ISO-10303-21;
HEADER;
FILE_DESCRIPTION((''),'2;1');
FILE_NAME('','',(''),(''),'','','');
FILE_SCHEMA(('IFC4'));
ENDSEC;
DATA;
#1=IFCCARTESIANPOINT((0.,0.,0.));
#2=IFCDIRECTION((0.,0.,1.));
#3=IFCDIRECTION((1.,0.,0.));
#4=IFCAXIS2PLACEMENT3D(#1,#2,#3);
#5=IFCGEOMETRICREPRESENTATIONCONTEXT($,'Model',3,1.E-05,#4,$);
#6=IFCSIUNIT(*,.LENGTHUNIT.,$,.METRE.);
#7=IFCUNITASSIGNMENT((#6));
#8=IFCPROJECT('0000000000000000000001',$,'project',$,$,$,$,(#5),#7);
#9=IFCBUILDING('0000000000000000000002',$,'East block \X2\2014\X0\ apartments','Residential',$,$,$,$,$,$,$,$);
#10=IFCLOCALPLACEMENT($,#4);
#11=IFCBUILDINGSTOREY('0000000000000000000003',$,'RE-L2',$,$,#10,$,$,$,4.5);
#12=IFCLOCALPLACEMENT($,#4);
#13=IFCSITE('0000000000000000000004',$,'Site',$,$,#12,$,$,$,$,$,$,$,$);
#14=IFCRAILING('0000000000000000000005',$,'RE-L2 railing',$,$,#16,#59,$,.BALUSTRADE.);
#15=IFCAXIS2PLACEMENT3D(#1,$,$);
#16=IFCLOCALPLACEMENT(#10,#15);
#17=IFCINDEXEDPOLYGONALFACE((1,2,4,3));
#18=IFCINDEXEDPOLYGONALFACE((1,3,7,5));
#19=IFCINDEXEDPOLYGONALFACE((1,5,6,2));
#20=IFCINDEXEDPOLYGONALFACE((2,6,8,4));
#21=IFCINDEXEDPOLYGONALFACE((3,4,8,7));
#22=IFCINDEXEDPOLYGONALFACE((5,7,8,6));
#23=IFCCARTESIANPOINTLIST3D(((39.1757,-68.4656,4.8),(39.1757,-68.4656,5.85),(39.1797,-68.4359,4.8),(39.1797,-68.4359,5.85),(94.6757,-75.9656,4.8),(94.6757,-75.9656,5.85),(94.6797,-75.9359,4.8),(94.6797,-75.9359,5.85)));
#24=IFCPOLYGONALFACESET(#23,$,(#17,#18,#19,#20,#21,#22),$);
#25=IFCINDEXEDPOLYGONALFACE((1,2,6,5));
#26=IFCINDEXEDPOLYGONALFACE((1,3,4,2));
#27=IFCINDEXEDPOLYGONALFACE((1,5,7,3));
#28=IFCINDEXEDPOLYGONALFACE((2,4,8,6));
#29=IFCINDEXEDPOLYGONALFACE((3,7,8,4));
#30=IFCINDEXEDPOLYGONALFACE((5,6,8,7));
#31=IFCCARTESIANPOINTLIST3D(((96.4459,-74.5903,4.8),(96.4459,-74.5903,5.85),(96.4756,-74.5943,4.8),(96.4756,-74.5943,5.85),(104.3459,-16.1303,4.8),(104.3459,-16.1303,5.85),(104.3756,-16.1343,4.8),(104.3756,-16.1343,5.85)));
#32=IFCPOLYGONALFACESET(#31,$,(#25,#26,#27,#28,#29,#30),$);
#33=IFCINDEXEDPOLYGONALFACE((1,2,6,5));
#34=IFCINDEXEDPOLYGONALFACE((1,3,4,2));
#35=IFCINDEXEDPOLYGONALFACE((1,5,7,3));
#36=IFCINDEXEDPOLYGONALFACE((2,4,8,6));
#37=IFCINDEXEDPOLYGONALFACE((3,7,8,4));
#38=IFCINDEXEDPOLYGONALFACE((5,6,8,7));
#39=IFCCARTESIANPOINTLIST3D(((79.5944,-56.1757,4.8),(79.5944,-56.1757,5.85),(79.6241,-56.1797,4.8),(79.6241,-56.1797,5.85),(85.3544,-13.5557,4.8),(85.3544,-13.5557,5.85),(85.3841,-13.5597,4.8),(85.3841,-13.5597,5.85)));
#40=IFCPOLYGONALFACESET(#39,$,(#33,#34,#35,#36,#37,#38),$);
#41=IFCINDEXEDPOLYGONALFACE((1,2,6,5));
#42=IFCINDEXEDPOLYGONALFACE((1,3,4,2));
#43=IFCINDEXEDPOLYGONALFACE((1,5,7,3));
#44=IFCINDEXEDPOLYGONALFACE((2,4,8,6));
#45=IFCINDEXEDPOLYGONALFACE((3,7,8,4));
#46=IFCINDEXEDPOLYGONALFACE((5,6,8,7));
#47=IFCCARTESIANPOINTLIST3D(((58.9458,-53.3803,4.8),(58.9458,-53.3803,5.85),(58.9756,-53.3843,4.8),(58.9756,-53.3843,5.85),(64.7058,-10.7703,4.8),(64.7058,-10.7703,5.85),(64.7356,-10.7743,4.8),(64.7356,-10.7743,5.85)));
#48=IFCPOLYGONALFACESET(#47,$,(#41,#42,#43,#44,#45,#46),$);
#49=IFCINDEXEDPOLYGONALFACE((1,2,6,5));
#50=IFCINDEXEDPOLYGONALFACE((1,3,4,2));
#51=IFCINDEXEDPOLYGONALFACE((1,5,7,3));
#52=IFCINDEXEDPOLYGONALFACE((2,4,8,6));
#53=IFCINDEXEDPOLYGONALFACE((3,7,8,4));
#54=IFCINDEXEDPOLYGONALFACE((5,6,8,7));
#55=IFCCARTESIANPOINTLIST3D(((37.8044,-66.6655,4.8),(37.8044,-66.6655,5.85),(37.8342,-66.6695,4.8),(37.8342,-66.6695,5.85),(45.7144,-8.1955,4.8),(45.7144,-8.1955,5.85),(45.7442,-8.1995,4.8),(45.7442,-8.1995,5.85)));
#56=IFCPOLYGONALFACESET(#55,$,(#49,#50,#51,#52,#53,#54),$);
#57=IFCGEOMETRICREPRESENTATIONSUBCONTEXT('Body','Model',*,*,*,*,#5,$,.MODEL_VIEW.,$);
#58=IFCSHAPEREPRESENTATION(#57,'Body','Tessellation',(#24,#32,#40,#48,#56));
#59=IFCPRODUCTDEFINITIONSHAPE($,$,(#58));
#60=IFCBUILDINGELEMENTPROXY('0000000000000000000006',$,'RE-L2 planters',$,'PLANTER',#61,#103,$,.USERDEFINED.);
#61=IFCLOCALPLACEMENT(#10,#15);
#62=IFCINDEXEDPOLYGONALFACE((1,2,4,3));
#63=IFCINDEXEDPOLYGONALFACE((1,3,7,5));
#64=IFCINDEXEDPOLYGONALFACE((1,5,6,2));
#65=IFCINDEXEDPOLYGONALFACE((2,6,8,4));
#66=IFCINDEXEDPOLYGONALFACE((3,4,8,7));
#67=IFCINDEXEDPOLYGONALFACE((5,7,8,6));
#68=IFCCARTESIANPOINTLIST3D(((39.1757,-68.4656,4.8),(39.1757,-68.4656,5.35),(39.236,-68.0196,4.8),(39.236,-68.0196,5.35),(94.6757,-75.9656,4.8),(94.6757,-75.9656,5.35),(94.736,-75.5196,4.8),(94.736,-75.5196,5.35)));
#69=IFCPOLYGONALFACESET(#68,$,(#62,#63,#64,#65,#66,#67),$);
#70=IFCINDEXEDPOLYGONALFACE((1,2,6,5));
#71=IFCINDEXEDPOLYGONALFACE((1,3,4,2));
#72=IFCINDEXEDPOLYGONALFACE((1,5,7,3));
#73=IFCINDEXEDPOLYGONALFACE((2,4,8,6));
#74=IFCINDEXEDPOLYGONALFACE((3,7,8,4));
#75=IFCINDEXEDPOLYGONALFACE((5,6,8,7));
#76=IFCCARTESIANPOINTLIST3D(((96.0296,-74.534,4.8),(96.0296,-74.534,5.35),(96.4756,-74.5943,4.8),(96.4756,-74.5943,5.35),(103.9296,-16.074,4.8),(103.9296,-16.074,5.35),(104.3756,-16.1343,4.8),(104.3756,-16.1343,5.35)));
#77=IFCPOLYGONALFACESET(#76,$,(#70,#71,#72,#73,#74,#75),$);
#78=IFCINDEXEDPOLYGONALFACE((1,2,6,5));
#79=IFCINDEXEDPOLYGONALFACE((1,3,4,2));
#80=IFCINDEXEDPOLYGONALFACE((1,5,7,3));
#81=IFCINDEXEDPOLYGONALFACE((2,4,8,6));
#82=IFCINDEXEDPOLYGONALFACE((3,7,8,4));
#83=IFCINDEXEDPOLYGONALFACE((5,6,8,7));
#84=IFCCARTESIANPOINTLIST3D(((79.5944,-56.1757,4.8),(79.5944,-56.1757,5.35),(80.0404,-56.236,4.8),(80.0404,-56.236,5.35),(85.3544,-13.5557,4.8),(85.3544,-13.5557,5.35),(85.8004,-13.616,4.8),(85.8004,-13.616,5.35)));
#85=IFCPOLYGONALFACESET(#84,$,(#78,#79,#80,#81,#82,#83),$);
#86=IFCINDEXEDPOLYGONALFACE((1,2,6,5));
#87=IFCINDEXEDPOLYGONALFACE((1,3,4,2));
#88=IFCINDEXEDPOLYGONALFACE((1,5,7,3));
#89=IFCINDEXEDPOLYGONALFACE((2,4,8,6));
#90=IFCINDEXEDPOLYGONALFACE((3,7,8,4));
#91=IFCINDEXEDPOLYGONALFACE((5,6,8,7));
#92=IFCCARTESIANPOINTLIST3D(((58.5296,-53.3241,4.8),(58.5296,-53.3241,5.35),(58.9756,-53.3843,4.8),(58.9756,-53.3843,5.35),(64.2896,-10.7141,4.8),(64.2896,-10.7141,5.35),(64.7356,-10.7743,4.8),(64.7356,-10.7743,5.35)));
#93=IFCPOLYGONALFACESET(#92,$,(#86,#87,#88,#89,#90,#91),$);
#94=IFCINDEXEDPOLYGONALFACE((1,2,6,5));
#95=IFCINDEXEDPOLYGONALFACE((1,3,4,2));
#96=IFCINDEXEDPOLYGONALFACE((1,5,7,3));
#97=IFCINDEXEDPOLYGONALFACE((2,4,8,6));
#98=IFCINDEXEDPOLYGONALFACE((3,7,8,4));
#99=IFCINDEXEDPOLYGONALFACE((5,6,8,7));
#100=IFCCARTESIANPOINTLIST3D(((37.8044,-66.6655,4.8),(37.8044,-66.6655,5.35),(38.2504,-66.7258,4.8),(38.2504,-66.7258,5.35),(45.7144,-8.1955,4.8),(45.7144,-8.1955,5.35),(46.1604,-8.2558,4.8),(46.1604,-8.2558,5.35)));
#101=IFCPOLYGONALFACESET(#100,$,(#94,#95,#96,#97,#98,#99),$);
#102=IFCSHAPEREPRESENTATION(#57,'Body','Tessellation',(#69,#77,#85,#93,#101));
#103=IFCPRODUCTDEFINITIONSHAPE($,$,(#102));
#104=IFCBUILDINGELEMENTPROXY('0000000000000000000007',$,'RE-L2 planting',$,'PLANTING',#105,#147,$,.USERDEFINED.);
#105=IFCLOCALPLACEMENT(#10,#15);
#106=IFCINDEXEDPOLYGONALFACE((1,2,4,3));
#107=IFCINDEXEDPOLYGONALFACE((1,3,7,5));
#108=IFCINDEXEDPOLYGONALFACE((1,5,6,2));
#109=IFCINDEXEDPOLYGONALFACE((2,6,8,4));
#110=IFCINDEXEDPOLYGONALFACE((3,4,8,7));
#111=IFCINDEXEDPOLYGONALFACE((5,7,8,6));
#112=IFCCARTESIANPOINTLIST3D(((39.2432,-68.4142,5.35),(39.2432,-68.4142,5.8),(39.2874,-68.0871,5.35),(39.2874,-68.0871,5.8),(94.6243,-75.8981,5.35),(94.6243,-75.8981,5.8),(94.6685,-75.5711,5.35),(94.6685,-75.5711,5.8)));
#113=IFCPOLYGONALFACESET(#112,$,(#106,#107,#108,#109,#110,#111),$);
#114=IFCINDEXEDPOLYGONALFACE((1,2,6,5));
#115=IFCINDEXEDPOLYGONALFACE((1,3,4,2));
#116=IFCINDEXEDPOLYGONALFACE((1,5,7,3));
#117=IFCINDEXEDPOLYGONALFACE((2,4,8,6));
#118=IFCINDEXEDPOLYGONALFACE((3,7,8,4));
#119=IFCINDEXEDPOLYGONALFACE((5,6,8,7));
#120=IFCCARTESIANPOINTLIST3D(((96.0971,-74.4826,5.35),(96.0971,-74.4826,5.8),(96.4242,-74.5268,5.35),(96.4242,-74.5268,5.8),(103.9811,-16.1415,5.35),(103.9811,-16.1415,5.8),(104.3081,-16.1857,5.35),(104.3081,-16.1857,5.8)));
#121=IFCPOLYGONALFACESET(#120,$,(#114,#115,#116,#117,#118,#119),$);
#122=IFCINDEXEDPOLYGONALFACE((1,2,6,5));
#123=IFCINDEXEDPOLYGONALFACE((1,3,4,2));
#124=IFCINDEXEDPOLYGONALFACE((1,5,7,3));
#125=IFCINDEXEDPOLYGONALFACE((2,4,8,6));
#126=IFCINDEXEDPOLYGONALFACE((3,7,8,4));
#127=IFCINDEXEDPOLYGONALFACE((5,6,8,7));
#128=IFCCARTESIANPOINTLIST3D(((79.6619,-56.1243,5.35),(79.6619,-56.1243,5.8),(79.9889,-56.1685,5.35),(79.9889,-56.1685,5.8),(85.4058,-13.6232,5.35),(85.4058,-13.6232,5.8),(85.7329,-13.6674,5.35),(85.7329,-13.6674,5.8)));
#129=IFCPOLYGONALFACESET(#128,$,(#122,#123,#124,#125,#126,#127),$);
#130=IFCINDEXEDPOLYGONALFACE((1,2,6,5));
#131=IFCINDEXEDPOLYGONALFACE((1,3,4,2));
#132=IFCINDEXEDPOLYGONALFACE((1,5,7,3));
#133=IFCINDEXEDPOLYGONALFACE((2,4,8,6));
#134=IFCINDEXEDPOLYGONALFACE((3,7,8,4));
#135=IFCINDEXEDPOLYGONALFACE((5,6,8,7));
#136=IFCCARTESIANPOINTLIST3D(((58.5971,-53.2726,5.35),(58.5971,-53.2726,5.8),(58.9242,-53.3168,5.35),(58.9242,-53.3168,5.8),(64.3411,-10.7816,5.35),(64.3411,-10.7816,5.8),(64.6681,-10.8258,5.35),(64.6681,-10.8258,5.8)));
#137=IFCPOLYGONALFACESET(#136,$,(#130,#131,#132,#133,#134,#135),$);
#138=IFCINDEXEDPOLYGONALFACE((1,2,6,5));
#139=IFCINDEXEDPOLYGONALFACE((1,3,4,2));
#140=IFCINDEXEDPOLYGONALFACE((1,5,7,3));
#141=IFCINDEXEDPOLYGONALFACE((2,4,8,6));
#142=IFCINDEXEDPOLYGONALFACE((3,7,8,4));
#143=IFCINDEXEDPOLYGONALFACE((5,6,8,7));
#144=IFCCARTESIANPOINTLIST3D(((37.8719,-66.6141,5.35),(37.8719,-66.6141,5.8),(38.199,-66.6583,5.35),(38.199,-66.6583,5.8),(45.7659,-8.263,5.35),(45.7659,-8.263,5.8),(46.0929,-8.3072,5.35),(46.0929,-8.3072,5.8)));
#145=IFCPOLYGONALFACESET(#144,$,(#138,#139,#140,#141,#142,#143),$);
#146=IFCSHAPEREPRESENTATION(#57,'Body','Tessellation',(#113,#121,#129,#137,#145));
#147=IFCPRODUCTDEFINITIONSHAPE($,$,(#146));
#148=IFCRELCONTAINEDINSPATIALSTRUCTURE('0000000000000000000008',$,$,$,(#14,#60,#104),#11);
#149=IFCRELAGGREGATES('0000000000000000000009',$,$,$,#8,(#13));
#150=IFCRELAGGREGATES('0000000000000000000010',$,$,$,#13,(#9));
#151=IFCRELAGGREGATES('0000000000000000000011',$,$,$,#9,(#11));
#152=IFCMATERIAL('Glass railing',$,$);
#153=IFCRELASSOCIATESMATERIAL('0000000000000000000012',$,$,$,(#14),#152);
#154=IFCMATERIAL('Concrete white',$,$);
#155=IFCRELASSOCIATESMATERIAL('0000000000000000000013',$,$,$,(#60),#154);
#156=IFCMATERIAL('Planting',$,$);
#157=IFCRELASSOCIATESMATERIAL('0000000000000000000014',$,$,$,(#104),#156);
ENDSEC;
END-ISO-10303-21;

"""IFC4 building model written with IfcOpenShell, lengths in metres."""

from ifc_helpers import new_model, si_unit, frame, origin_with_axes, place, context, subcontext, project, spatial, polyline, outline, extrude, material, element, save


model = new_model("IFC4")

# Units and contexts
model_context = context("Model", 3, precision=1e-05, world=origin_with_axes())
body_context = subcontext(model_context, "Body", "Model", "MODEL_VIEW")
ifc_project = project(units=[si_unit("LENGTHUNIT", "METRE")], contexts=[model_context])

# Site, building, storey
site_placement = place(None, origin_with_axes())
site = spatial("IfcSite", under=ifc_project, at=site_placement, Name="Site")
building = spatial("IfcBuilding", under=site, Name="East block — apartments", Description="Residential")
storey_placement = place(None, origin_with_axes())
storey = spatial("IfcBuildingStorey", under=building, at=storey_placement, Name="RE-L2", Elevation=4.5)

# Railing
ifc_material_1 = material(Name="Glass railing")
railing_placement = place(storey_placement, origin_with_axes())
element("IfcRailing", 1, at=railing_placement, inside=storey, material=ifc_material_1, Name="RE-L2 railing", PredefinedType="BALUSTRADE", context=body_context, shape_type="SweptSolid", body=[
    extrude(outline(polyline([(39.1757, -68.4656), (94.6757, -75.9656), (94.6797, -75.9359), (39.1797, -68.4359), (39.1757, -68.4656)])), frame((0.0, 0.0, 4.8), z_axis=(0.0, 0.0, 1.0), x_axis=(1.0, 0.0, 0.0)), (0.0, 0.0, 1.0), 1.05),
    extrude(outline(polyline([(96.4756, -74.5943), (104.3756, -16.1343), (104.3459, -16.1303), (96.4459, -74.5903), (96.4756, -74.5943)])), frame((0.0, 0.0, 4.8), z_axis=(0.0, 0.0, 1.0), x_axis=(1.0, 0.0, 0.0)), (0.0, 0.0, 1.0), 1.05),
    extrude(outline(polyline([(85.3544, -13.5557), (79.5944, -56.1757), (79.6241, -56.1797), (85.3841, -13.5597), (85.3544, -13.5557)])), frame((0.0, 0.0, 4.8), z_axis=(0.0, 0.0, 1.0), x_axis=(1.0, 0.0, 0.0)), (0.0, 0.0, 1.0), 1.05),
    extrude(outline(polyline([(58.9756, -53.3843), (64.7356, -10.7743), (64.7058, -10.7703), (58.9458, -53.3803), (58.9756, -53.3843)])), frame((0.0, 0.0, 4.8), z_axis=(0.0, 0.0, 1.0), x_axis=(1.0, 0.0, 0.0)), (0.0, 0.0, 1.0), 1.05),
    extrude(outline(polyline([(45.7144, -8.1955), (37.8044, -66.6655), (37.8342, -66.6695), (45.7442, -8.1995), (45.7144, -8.1955)])), frame((0.0, 0.0, 4.8), z_axis=(0.0, 0.0, 1.0), x_axis=(1.0, 0.0, 0.0)), (0.0, 0.0, 1.0), 1.05),
])

# Building element proxies
ifc_material_2 = material(Name="Concrete white")
proxy_1_placement = place(storey_placement, origin_with_axes())
element("IfcBuildingElementProxy", 2, at=proxy_1_placement, inside=storey, material=ifc_material_2, Name="RE-L2 planters", ObjectType="PLANTER", PredefinedType="USERDEFINED", context=body_context, shape_type="SweptSolid", body=[
    extrude(outline(polyline([(39.1757, -68.4656), (94.6757, -75.9656), (94.736, -75.5196), (39.236, -68.0196), (39.1757, -68.4656)])), frame((0.0, 0.0, 4.8), z_axis=(0.0, 0.0, 1.0), x_axis=(1.0, 0.0, 0.0)), (0.0, 0.0, 1.0), 0.55),
    extrude(outline(polyline([(96.4756, -74.5943), (104.3756, -16.1343), (103.9296, -16.074), (96.0296, -74.534), (96.4756, -74.5943)])), frame((0.0, 0.0, 4.8), z_axis=(0.0, 0.0, 1.0), x_axis=(1.0, 0.0, 0.0)), (0.0, 0.0, 1.0), 0.55),
    extrude(outline(polyline([(85.3544, -13.5557), (79.5944, -56.1757), (80.0404, -56.236), (85.8004, -13.616), (85.3544, -13.5557)])), frame((0.0, 0.0, 4.8), z_axis=(0.0, 0.0, 1.0), x_axis=(1.0, 0.0, 0.0)), (0.0, 0.0, 1.0), 0.55),
    extrude(outline(polyline([(58.9756, -53.3843), (64.7356, -10.7743), (64.2896, -10.7141), (58.5296, -53.3241), (58.9756, -53.3843)])), frame((0.0, 0.0, 4.8), z_axis=(0.0, 0.0, 1.0), x_axis=(1.0, 0.0, 0.0)), (0.0, 0.0, 1.0), 0.55),
    extrude(outline(polyline([(45.7144, -8.1955), (37.8044, -66.6655), (38.2504, -66.7258), (46.1604, -8.2558), (45.7144, -8.1955)])), frame((0.0, 0.0, 4.8), z_axis=(0.0, 0.0, 1.0), x_axis=(1.0, 0.0, 0.0)), (0.0, 0.0, 1.0), 0.55),
])
ifc_material_3 = material(Name="Planting")
proxy_2_placement = place(storey_placement, origin_with_axes())
element("IfcBuildingElementProxy", 3, at=proxy_2_placement, inside=storey, material=ifc_material_3, Name="RE-L2 planting", ObjectType="PLANTING", PredefinedType="USERDEFINED", context=body_context, shape_type="SweptSolid", body=[
    extrude(outline(polyline([(39.2432, -68.4142), (94.6243, -75.8981), (94.6685, -75.5711), (39.2874, -68.0871), (39.2432, -68.4142)])), frame((0.0, 0.0, 5.35), z_axis=(0.0, 0.0, 1.0), x_axis=(1.0, 0.0, 0.0)), (0.0, 0.0, 1.0), 0.45),
    extrude(outline(polyline([(96.4242, -74.5268), (104.3081, -16.1857), (103.9811, -16.1415), (96.0971, -74.4826), (96.4242, -74.5268)])), frame((0.0, 0.0, 5.35), z_axis=(0.0, 0.0, 1.0), x_axis=(1.0, 0.0, 0.0)), (0.0, 0.0, 1.0), 0.45),
    extrude(outline(polyline([(85.4058, -13.6232), (79.6619, -56.1243), (79.9889, -56.1685), (85.7329, -13.6674), (85.4058, -13.6232)])), frame((0.0, 0.0, 5.35), z_axis=(0.0, 0.0, 1.0), x_axis=(1.0, 0.0, 0.0)), (0.0, 0.0, 1.0), 0.45),
    extrude(outline(polyline([(58.9242, -53.3168), (64.6681, -10.8258), (64.3411, -10.7816), (58.5971, -53.2726), (58.9242, -53.3168)])), frame((0.0, 0.0, 5.35), z_axis=(0.0, 0.0, 1.0), x_axis=(1.0, 0.0, 0.0)), (0.0, 0.0, 1.0), 0.45),
    extrude(outline(polyline([(45.7659, -8.263), (37.8719, -66.6141), (38.199, -66.6583), (46.0929, -8.3072), (45.7659, -8.263)])), frame((0.0, 0.0, 5.35), z_axis=(0.0, 0.0, 1.0), x_axis=(1.0, 0.0, 0.0)), (0.0, 0.0, 1.0), 0.45),
])

save(model, "model.ifc")
